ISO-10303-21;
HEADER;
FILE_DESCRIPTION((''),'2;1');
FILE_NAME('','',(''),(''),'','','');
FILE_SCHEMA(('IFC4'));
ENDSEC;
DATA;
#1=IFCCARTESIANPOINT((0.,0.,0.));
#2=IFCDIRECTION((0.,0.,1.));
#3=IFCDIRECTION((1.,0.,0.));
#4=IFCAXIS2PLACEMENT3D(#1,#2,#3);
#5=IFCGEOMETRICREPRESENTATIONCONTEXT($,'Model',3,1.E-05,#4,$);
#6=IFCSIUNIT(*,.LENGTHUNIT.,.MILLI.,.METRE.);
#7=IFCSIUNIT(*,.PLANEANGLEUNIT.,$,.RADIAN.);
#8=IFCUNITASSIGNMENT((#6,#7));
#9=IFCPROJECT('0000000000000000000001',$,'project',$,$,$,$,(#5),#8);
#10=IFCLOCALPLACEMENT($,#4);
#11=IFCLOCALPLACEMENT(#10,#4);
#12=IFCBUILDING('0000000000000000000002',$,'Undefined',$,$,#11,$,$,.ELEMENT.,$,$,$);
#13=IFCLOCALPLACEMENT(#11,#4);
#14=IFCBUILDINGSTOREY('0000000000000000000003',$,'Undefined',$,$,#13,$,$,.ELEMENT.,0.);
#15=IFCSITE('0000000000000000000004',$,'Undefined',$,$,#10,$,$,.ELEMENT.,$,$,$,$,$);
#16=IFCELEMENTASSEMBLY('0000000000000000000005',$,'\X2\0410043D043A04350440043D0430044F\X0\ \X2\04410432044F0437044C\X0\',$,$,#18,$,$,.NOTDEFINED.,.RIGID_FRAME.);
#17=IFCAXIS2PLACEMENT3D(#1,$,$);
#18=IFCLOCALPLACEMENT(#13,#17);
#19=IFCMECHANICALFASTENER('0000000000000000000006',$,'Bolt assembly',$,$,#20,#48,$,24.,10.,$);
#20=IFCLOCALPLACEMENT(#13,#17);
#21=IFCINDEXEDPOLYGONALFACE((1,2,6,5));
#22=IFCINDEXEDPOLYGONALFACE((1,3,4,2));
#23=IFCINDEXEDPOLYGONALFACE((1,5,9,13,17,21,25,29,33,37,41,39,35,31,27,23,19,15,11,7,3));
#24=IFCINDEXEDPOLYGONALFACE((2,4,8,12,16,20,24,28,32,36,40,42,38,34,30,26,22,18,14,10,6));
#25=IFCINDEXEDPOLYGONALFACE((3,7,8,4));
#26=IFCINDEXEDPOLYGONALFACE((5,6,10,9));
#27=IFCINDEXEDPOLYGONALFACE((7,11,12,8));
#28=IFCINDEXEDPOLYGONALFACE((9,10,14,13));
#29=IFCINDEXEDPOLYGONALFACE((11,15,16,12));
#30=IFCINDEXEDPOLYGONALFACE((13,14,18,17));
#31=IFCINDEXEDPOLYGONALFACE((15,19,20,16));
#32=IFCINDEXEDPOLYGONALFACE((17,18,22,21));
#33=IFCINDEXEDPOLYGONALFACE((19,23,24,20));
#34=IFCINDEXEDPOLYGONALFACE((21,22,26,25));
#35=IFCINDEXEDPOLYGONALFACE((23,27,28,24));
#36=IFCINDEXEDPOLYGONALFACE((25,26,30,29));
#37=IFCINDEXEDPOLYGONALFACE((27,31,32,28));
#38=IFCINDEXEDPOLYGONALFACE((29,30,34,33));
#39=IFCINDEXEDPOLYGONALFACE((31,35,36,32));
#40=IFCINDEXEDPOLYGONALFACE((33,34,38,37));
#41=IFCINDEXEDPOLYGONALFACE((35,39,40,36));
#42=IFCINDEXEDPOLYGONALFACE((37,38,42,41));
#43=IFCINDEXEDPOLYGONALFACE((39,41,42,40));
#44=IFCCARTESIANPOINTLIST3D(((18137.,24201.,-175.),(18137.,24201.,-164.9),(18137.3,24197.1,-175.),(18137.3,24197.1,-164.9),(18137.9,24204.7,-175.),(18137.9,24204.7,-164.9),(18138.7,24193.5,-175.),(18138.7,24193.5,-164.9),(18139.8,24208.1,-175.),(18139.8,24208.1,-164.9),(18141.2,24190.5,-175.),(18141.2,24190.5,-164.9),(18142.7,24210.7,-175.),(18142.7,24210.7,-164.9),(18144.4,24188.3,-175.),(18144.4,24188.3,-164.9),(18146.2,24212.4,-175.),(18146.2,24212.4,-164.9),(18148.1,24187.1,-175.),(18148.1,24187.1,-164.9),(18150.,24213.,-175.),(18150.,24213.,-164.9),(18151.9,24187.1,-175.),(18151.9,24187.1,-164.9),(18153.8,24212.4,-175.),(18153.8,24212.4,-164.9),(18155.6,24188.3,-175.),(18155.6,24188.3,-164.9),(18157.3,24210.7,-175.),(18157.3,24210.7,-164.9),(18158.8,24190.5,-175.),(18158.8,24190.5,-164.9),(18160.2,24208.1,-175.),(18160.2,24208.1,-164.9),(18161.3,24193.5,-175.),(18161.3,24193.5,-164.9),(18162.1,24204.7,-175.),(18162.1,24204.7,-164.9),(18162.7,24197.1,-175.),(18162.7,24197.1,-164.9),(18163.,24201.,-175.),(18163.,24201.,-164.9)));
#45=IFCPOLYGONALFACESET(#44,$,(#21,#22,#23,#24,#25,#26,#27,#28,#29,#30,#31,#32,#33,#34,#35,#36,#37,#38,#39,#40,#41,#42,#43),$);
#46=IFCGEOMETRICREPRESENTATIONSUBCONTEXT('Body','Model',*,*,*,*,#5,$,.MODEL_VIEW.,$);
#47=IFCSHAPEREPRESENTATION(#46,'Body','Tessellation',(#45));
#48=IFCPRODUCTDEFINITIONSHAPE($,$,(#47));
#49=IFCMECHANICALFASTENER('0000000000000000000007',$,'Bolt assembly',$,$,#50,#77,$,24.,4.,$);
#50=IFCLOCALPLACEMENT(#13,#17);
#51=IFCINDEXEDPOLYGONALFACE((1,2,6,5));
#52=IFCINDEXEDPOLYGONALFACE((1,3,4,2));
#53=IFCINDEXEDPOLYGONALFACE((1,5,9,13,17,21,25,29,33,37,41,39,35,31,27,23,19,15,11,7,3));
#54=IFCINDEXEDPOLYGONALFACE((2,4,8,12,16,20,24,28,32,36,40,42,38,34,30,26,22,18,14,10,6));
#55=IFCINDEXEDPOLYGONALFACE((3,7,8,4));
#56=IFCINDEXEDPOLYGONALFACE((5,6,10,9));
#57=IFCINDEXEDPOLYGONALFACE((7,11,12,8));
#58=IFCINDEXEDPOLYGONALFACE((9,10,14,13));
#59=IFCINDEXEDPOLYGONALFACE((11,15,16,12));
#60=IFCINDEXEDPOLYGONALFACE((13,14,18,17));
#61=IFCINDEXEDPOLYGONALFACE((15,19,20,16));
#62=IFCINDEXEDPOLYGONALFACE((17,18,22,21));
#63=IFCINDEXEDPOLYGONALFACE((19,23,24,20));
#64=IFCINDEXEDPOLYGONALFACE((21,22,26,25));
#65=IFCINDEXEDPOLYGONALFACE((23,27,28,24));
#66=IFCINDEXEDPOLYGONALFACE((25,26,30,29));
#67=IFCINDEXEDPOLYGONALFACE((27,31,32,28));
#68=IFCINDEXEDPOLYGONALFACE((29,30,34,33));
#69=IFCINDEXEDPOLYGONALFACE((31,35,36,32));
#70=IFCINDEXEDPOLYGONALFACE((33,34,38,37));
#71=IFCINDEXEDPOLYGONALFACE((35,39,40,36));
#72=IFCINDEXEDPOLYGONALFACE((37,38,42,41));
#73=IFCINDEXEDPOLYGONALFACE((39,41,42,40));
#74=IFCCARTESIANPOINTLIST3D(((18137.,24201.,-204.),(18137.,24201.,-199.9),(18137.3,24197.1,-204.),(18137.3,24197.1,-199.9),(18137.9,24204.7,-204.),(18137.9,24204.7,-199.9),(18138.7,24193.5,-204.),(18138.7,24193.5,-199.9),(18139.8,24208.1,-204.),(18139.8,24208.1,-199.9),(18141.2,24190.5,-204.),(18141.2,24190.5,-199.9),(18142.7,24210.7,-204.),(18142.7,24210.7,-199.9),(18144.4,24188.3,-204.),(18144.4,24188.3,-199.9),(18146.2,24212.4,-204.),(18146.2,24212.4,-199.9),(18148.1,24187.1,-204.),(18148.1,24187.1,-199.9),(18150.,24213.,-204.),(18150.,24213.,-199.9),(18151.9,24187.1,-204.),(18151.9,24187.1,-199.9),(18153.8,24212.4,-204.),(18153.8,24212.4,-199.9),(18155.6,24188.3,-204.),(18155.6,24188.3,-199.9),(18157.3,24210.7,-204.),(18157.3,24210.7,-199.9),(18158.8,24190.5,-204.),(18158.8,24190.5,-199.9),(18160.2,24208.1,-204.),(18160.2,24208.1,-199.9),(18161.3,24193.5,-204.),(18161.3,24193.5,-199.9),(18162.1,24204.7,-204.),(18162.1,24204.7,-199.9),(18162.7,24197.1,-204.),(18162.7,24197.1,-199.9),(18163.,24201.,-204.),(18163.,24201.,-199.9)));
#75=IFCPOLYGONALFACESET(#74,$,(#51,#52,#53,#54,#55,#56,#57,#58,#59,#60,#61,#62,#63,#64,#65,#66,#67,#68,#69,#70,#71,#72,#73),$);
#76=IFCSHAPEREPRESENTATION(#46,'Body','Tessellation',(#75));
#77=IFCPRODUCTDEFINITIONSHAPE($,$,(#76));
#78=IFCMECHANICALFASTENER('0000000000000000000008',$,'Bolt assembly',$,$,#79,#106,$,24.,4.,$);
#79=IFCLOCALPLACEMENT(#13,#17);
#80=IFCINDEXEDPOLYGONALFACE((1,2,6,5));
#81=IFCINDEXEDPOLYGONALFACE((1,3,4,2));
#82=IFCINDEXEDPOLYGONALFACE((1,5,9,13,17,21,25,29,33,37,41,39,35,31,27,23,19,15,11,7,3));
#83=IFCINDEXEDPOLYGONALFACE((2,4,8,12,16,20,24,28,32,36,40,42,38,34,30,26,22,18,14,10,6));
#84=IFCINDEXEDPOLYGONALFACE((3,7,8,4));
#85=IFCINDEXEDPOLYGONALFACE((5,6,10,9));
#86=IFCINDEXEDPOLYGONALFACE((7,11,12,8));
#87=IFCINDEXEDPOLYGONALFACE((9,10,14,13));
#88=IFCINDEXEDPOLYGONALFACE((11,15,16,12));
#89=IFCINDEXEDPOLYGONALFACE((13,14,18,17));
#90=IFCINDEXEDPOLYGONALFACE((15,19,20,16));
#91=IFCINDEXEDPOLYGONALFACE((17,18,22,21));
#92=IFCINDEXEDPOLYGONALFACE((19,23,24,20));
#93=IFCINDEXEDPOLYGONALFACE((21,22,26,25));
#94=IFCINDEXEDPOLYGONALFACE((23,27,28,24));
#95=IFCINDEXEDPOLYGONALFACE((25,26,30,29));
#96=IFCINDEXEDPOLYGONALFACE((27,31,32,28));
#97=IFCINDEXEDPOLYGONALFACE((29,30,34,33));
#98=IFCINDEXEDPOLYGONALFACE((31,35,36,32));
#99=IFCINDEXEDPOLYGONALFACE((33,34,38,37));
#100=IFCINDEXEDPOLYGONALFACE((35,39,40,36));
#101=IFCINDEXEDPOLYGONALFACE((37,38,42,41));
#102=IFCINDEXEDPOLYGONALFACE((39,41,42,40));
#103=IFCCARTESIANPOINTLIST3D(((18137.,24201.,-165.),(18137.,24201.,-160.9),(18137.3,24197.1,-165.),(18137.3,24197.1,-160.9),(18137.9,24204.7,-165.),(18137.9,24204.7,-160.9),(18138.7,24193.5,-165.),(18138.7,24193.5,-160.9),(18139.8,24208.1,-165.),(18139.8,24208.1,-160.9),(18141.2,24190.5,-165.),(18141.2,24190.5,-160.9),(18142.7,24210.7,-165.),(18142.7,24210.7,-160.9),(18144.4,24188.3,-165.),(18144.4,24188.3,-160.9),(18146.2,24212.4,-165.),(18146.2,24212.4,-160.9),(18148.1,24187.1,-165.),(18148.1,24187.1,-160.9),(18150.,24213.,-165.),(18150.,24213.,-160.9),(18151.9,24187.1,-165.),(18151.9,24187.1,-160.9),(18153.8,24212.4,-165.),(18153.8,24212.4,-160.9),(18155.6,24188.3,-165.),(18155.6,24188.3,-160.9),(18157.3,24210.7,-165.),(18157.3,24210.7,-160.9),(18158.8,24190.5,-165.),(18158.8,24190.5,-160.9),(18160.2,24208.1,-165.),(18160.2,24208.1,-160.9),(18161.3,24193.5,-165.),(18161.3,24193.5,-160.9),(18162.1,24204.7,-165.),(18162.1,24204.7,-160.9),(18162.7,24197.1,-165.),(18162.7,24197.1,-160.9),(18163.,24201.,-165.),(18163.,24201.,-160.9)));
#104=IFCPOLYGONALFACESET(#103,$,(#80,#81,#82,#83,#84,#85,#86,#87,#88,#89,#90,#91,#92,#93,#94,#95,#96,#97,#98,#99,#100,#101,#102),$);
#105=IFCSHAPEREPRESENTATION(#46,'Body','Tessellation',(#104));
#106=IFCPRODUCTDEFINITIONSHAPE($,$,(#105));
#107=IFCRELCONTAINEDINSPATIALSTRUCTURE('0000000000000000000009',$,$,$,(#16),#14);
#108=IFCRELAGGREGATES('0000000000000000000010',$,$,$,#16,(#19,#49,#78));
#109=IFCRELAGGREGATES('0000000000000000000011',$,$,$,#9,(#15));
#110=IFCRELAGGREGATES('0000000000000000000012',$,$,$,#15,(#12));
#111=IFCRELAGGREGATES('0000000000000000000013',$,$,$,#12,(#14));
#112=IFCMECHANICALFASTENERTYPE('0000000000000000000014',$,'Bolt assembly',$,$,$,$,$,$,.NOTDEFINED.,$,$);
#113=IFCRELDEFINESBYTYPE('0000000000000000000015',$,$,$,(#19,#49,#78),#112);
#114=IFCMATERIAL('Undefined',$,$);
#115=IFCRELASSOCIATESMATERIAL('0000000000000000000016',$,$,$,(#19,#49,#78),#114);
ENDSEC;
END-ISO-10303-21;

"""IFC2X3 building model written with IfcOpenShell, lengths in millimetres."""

from ifc_helpers import new_model, si_unit, frame, origin_with_axes, origin_2d_with_axis, place, context, subcontext, project, spatial, circle, extrude, source, transform, mapped, material, type_object, element, aggregate, save


model = new_model("IFC2X3")

# Units and contexts
model_context = context("Model", 3, precision=1e-05, world=origin_with_axes())
body_context = subcontext(model_context, "Body", "Model", "MODEL_VIEW")
ifc_project = project(units=[si_unit("LENGTHUNIT", "METRE", prefix="MILLI"), si_unit("PLANEANGLEUNIT", "RADIAN")], contexts=[model_context])

# Site, building, storey
site_placement = place(None, origin_with_axes())
site = spatial("IfcSite", under=ifc_project, at=site_placement, Name="Undefined", CompositionType="ELEMENT")
building_placement = place(site_placement, origin_with_axes())
building = spatial("IfcBuilding", under=site, at=building_placement, Name="Undefined", CompositionType="ELEMENT")
storey_placement = place(building_placement, origin_with_axes())
storey = spatial("IfcBuildingStorey", under=building, at=storey_placement, Name="Undefined", CompositionType="ELEMENT", Elevation=0.0)

# Element assembly
assembly_1_placement = place(storey_placement, origin_with_axes())
assembly_1 = element("IfcElementAssembly", 1, at=assembly_1_placement, inside=storey, Name="Анкерная связь", AssemblyPlace="NOTDEFINED", PredefinedType="RIGID_FRAME")

# Mechanical fasteners
ifc_material_1 = material(Name="Undefined")
mechanical_fastener_type = type_object("IfcMechanicalFastenerType", Name="Bolt assembly")
shared_shape_1 = source(origin_with_axes(), body_context, "Body", "SweptSolid", [
    extrude(circle(Radius=13.0, at=origin_2d_with_axis()), frame((0.0, 0.0, 0.0), z_axis=(0.0, 1.0, 0.0), x_axis=(1.0, 0.0, 0.0)), (0.0, 0.0, 1.0), 10.1),
])
mechanical_fastener_1_placement = place(assembly_1_placement, frame((18150.0, 24200.0, -175.0), z_axis=(1.0, 0.0, 0.0), x_axis=(0.0, 1.0, 0.0)))
mechanical_fastener_1 = element("IfcMechanicalFastener", 2, at=mechanical_fastener_1_placement, type_object=mechanical_fastener_type, material=ifc_material_1, Name="Bolt assembly", NominalDiameter=24.0, NominalLength=10.0, context=body_context, shape_type="MappedRepresentation", body=[
    mapped(shared_shape_1, transform((0.0, 0.0, 0.0))),
])
shared_shape_2 = source(origin_with_axes(), body_context, "Body", "SweptSolid", [
    extrude(circle(Radius=13.0, at=origin_2d_with_axis()), frame((0.0, -4.0, 0.0), z_axis=(0.0, 1.0, 0.0), x_axis=(1.0, 0.0, 0.0)), (0.0, 0.0, 1.0), 4.1),
])
mechanical_fastener_2_placement = place(assembly_1_placement, frame((18150.0, 24200.0, -200.0), z_axis=(1.0, 0.0, 0.0), x_axis=(0.0, 1.0, 0.0)))
mechanical_fastener_2 = element("IfcMechanicalFastener", 3, at=mechanical_fastener_2_placement, type_object=mechanical_fastener_type, material=ifc_material_1, Name="Bolt assembly", NominalDiameter=24.0, NominalLength=4.0, context=body_context, shape_type="MappedRepresentation", body=[
    mapped(shared_shape_2, transform((0.0, 0.0, 0.0))),
])
mechanical_fastener_3_placement = place(assembly_1_placement, frame((18150.0, 24200.0, -161.0), z_axis=(1.0, 0.0, 0.0), x_axis=(0.0, 1.0, 0.0)))
mechanical_fastener_3 = element("IfcMechanicalFastener", 4, at=mechanical_fastener_3_placement, type_object=mechanical_fastener_type, material=ifc_material_1, Name="Bolt assembly", NominalDiameter=24.0, NominalLength=4.0, context=body_context, shape_type="MappedRepresentation", body=[
    mapped(shared_shape_2, transform((0.0, 0.0, 0.0))),
])
aggregate(assembly_1, [mechanical_fastener_1, mechanical_fastener_2, mechanical_fastener_3])

save(model, "model.ifc")
